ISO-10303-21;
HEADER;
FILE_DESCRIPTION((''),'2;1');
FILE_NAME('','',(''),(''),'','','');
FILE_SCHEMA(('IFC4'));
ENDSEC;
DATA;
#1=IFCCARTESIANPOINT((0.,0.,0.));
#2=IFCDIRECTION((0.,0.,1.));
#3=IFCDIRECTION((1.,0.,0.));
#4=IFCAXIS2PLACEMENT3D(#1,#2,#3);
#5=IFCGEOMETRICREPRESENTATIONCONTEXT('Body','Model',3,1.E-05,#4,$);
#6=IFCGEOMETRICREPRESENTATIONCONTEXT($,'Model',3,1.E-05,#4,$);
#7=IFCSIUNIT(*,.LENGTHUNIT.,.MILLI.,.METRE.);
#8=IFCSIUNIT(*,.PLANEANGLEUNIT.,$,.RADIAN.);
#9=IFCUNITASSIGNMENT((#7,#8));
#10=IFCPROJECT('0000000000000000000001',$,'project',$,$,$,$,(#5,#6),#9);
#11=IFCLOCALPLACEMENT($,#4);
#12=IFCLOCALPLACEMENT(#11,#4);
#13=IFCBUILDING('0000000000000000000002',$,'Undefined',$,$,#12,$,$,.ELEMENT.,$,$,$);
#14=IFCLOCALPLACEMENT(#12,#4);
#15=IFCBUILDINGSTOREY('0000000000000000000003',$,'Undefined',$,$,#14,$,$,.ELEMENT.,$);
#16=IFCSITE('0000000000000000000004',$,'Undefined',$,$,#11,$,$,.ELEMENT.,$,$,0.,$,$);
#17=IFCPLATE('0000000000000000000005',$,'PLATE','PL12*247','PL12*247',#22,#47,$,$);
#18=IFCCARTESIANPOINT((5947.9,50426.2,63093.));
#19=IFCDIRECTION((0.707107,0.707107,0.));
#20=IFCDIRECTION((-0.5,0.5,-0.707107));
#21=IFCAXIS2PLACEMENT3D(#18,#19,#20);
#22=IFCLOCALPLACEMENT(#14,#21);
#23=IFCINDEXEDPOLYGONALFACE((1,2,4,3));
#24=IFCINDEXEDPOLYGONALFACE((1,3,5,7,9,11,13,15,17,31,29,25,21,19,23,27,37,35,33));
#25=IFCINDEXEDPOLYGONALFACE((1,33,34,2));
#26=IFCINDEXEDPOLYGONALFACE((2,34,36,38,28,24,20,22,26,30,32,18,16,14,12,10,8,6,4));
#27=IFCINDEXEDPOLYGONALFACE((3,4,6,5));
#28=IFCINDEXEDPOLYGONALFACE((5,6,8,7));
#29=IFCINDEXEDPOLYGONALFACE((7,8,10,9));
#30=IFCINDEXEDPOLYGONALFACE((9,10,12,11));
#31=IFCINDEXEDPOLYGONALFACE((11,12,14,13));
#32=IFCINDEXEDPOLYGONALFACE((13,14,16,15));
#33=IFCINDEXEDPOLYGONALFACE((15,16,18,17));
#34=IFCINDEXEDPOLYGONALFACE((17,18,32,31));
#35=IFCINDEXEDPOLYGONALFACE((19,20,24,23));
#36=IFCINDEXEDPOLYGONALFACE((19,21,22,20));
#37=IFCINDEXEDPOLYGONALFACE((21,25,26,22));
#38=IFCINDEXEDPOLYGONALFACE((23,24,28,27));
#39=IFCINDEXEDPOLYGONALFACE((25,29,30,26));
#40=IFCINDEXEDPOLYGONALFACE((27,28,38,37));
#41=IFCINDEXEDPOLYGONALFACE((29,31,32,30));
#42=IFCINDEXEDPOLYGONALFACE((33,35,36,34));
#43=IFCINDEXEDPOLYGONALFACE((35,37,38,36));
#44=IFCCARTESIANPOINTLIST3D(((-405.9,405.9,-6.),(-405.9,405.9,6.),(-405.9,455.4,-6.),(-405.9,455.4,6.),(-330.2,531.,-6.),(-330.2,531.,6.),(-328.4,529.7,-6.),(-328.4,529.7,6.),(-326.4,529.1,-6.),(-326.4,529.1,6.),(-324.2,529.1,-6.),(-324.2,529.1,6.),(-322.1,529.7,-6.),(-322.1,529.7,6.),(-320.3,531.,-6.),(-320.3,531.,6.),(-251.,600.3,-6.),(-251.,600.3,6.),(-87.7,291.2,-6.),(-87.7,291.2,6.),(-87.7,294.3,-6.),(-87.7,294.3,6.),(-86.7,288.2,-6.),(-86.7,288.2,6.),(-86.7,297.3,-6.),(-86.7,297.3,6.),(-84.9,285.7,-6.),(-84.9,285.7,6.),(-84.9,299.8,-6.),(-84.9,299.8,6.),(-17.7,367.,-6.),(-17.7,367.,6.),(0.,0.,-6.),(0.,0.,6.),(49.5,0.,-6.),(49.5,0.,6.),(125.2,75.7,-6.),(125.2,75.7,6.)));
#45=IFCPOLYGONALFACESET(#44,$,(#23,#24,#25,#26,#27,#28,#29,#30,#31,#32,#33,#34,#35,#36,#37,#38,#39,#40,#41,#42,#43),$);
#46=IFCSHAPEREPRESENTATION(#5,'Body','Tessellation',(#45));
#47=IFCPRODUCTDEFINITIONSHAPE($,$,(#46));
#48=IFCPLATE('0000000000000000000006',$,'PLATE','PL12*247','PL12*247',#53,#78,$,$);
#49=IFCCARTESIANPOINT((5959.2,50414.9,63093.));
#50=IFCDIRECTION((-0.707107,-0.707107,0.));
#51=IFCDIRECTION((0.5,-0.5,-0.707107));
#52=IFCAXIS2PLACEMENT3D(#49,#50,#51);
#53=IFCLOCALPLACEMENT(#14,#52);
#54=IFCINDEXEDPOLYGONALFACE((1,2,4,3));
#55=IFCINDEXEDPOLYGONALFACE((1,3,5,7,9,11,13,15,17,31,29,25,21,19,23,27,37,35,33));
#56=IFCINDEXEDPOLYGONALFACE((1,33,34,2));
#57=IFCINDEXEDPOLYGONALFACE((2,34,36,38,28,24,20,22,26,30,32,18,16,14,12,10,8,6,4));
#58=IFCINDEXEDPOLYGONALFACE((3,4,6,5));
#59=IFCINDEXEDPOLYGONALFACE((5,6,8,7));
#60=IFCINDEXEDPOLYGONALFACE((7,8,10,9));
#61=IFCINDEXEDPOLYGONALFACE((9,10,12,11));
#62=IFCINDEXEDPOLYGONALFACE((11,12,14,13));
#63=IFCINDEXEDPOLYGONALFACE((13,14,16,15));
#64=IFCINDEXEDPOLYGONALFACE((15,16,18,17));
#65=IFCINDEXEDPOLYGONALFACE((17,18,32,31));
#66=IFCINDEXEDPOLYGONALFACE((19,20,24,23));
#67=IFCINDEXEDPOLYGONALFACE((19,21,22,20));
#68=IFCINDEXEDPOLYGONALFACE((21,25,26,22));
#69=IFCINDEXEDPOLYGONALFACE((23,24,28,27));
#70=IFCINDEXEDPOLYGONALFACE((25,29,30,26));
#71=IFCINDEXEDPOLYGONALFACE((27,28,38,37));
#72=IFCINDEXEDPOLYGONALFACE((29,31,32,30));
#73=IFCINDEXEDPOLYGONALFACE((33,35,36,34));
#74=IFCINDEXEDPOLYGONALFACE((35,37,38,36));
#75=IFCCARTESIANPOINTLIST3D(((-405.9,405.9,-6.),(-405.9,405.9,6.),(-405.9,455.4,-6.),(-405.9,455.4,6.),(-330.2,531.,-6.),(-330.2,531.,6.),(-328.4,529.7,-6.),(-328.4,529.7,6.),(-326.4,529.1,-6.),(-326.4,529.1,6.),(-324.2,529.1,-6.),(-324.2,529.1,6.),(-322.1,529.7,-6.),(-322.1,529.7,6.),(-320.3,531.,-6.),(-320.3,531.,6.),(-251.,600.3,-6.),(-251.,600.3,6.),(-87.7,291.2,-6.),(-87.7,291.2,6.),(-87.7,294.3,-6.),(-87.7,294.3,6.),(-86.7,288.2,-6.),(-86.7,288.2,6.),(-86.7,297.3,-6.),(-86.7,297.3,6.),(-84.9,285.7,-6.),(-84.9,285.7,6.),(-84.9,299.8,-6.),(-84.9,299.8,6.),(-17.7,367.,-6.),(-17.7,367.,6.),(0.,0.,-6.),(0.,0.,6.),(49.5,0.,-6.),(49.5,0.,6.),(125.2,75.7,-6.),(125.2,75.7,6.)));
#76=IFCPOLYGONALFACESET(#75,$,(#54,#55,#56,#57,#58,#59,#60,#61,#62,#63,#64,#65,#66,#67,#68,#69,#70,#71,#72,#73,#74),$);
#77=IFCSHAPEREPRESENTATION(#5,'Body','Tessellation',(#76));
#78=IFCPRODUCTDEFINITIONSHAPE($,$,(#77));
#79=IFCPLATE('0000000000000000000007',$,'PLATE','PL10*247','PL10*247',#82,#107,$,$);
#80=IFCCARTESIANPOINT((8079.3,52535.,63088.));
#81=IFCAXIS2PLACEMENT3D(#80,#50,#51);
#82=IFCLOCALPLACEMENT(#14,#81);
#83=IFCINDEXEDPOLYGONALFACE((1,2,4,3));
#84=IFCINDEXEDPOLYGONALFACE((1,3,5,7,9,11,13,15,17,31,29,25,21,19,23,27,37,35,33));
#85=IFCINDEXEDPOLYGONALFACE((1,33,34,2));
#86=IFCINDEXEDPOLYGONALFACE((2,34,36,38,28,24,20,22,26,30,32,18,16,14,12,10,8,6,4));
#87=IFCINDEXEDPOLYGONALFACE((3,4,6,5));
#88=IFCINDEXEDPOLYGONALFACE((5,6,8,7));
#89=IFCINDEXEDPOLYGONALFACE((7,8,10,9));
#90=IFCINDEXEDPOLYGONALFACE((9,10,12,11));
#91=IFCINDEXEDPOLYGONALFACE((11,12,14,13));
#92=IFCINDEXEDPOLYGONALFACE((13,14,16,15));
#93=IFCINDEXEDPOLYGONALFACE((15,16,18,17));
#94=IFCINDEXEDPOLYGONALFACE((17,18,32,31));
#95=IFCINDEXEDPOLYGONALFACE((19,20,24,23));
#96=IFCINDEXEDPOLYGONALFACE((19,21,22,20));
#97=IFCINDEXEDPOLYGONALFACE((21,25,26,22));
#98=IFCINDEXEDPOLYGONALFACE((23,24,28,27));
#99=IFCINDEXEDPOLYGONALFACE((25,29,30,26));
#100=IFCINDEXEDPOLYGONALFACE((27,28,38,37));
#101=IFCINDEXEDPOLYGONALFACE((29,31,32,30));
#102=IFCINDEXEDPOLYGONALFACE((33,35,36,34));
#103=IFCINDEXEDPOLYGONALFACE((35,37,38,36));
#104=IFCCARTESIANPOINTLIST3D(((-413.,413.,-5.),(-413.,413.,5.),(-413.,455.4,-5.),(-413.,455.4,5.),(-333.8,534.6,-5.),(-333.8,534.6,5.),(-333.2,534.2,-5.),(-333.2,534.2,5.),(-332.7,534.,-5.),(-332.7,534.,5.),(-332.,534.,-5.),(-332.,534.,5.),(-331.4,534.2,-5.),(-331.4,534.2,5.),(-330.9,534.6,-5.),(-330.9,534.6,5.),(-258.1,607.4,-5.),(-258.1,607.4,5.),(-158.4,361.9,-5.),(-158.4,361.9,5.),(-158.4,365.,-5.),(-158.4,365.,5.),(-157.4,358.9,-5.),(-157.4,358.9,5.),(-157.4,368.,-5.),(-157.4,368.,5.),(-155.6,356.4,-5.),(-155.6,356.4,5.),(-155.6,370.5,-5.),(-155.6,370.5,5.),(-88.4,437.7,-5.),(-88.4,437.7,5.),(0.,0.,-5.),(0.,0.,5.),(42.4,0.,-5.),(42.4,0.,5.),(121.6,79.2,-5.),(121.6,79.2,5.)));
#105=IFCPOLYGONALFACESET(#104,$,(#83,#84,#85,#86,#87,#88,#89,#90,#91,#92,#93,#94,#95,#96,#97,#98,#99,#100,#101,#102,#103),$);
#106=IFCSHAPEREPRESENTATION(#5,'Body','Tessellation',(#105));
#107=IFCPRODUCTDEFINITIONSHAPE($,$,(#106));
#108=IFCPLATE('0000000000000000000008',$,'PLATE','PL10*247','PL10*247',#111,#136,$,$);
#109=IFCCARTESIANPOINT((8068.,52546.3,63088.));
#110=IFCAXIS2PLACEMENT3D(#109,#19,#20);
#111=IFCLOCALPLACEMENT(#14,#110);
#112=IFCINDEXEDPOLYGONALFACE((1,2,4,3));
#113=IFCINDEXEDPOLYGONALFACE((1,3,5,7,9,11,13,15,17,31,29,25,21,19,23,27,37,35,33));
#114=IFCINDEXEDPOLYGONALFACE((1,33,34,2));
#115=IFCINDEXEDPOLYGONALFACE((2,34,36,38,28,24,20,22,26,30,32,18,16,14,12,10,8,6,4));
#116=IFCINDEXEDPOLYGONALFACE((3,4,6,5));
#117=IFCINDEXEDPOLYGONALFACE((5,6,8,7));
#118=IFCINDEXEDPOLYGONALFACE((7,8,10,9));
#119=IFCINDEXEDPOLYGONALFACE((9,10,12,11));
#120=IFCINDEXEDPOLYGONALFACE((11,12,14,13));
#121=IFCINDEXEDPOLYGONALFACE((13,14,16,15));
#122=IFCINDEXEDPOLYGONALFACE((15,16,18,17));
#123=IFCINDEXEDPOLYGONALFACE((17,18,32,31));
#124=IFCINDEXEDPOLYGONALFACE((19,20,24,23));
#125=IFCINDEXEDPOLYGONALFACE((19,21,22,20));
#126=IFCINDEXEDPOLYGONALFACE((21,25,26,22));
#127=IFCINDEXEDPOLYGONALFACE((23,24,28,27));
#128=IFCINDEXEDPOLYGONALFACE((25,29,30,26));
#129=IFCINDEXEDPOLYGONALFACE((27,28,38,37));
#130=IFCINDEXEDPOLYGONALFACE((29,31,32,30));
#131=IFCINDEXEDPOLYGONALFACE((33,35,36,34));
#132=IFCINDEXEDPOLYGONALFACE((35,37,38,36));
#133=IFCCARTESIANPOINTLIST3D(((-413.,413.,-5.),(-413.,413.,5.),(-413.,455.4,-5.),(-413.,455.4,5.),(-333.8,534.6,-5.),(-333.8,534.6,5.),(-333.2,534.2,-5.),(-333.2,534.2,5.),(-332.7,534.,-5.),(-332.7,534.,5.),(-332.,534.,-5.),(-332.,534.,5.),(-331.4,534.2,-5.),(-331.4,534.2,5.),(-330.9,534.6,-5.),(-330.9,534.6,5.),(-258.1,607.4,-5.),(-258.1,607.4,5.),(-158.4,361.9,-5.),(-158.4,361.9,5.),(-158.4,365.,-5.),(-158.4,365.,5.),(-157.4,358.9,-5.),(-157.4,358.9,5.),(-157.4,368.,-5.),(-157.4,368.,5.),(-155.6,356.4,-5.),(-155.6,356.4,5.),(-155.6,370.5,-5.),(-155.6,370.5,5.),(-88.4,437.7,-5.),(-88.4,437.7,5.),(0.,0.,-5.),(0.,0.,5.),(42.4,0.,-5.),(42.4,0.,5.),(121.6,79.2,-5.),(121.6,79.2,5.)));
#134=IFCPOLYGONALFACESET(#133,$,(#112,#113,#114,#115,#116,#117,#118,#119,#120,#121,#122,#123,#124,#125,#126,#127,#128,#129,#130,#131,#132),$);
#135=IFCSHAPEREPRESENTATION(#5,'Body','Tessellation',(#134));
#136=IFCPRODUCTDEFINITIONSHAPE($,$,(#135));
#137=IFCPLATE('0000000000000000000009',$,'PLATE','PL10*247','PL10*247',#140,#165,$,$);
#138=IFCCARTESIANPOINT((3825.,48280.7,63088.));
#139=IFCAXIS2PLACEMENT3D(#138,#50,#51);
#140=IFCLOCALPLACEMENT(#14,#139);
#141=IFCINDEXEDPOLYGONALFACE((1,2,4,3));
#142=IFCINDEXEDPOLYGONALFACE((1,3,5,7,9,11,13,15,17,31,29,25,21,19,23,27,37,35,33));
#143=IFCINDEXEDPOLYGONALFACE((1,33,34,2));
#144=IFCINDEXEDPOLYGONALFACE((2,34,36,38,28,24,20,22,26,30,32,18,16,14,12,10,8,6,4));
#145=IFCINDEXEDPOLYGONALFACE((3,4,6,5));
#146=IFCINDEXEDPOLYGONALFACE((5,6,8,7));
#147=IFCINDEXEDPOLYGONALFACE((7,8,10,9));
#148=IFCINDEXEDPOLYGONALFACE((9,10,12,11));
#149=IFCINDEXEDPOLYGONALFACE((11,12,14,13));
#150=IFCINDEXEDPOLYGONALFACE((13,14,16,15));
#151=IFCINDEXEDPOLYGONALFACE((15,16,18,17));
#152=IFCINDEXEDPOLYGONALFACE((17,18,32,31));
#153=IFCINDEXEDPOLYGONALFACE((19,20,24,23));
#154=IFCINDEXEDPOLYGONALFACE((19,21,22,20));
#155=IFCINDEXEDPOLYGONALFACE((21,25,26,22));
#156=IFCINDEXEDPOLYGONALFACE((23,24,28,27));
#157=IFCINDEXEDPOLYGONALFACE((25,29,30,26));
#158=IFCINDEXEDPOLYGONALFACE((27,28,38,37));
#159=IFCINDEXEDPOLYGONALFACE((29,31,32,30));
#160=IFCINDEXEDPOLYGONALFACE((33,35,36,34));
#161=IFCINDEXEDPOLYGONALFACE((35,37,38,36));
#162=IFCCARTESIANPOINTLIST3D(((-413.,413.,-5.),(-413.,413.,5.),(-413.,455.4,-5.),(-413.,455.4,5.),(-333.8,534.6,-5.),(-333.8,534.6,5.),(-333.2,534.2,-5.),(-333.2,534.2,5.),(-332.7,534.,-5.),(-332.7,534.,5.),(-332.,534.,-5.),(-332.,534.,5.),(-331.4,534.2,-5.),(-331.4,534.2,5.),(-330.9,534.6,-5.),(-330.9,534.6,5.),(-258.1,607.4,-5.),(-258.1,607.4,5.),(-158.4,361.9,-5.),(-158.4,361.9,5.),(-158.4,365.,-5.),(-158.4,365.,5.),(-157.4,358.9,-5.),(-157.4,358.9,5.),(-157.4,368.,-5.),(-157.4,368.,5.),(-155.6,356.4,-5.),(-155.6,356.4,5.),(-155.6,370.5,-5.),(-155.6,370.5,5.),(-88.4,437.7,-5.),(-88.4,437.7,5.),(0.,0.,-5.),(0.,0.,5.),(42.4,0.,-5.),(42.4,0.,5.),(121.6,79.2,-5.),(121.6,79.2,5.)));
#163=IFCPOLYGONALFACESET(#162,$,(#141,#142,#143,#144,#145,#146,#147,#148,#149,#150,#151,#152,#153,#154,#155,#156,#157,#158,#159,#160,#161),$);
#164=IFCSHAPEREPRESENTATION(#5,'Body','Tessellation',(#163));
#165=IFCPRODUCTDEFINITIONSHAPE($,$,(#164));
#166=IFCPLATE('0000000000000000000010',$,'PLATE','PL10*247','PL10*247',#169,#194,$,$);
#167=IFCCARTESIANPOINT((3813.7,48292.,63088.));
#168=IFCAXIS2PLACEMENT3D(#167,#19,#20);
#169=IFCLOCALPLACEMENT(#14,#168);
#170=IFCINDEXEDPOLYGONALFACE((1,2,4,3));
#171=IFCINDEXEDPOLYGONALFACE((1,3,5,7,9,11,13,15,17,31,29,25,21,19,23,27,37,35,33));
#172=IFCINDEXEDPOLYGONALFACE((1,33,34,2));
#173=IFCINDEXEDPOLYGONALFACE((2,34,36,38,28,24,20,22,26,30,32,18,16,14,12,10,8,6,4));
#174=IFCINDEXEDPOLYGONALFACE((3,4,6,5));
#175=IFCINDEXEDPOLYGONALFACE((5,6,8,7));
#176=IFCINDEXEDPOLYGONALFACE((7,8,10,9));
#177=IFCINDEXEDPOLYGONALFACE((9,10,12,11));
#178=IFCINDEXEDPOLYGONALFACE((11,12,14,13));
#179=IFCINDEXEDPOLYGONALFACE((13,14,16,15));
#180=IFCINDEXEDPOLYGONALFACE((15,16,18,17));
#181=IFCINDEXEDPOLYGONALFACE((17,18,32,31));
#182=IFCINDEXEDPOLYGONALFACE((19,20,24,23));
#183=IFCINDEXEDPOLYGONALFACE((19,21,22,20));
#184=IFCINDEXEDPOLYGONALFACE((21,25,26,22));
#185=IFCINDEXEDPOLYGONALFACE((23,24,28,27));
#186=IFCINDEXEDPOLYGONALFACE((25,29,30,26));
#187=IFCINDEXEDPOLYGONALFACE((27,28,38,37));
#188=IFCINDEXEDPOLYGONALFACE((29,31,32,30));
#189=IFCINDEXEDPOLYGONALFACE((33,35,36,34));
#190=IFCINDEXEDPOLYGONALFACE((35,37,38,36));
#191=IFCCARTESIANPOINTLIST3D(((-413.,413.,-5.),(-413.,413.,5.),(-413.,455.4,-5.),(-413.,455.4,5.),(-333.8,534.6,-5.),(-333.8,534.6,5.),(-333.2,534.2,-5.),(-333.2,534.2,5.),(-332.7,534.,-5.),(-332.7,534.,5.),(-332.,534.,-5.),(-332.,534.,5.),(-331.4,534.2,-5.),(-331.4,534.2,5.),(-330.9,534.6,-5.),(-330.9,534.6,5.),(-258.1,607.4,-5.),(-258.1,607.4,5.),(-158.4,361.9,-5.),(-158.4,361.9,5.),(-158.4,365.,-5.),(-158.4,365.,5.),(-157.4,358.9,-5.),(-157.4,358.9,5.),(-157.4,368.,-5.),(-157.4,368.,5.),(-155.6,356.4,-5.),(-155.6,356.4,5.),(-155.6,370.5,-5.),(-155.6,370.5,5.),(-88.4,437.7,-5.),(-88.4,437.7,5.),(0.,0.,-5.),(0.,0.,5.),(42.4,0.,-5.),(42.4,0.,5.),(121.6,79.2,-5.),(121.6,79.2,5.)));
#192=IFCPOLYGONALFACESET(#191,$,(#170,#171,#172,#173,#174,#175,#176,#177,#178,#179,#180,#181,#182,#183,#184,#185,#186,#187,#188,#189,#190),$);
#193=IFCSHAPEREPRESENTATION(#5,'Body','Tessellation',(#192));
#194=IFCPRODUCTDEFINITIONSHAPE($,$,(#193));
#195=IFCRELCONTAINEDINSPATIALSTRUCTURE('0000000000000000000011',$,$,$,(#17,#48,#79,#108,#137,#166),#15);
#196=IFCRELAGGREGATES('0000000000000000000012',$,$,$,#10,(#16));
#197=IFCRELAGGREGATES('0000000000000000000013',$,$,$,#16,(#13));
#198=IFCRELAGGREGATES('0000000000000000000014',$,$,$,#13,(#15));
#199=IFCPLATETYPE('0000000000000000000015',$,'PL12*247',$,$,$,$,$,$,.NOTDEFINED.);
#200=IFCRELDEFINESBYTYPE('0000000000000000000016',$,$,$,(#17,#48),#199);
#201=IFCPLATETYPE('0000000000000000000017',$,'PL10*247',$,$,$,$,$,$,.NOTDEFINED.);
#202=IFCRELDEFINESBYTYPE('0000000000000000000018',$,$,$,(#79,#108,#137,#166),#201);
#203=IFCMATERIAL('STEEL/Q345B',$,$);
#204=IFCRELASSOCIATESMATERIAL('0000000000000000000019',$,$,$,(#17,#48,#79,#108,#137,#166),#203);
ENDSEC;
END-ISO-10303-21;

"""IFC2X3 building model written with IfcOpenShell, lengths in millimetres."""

from ifc_helpers import new_model, si_unit, frame, origin_with_axes, place, context, project, spatial, polyline, outline, extrude, material, type_object, element, save


model = new_model("IFC2X3")

# Units and contexts
model_context_1 = context("Model", 3, precision=1e-05, world=origin_with_axes(), identifier="Body")
model_context_2 = context("Model", 3, precision=1e-05, world=origin_with_axes())
ifc_project = project(units=[si_unit("LENGTHUNIT", "METRE", prefix="MILLI"), si_unit("PLANEANGLEUNIT", "RADIAN")], contexts=[model_context_1, model_context_2])

# Site, building, storey
site_placement = place(None, origin_with_axes())
site = spatial("IfcSite", under=ifc_project, at=site_placement, Name="Undefined", CompositionType="ELEMENT", RefElevation=0.0)
building_placement = place(site_placement, origin_with_axes())
building = spatial("IfcBuilding", under=site, at=building_placement, Name="Undefined", CompositionType="ELEMENT")
storey_placement = place(building_placement, origin_with_axes())
storey = spatial("IfcBuildingStorey", under=building, at=storey_placement, Name="Undefined", CompositionType="ELEMENT")

# Shared definitions
ifc_material_1 = material(Name="STEEL/Q345B")

# Plates
plate_type_1 = type_object("IfcPlateType", Name="PL12*247", PredefinedType="NOTDEFINED")
plate_1_placement = place(storey_placement, frame((5947.9, 50426.2, 63093.0), z_axis=(0.707107, 0.707107, 0.0), x_axis=(-0.5, 0.5, -0.707107)))
element("IfcPlate", 1, at=plate_1_placement, inside=storey, type_object=plate_type_1, material=ifc_material_1, Name="PLATE", Description="PL12*247", ObjectType="PL12*247", context=model_context_1, shape_type="SweptSolid", body=[
    extrude(outline(polyline([(0.0, 0.0), (49.5, 0.0), (125.2, 75.7), (-84.9, 285.7), (-86.7, 288.2), (-87.7, 291.2), (-87.7, 294.3), (-86.7, 297.3), (-84.9, 299.8), (-17.7, 367.0), (-251.0, 600.3), (-320.3, 531.0), (-322.1, 529.7), (-324.2, 529.1), (-326.4, 529.1), (-328.4, 529.7), (-330.2, 531.0), (-405.9, 455.4), (-405.9, 405.9), (0.0, 0.0)])), frame((0.0, 0.0, -6.0), z_axis=(0.0, 0.0, 1.0), x_axis=(1.0, 0.0, 0.0)), (0.0, 0.0, 1.0), 12.0),
])
plate_2_placement = place(storey_placement, frame((5959.2, 50414.9, 63093.0), z_axis=(-0.707107, -0.707107, 0.0), x_axis=(0.5, -0.5, -0.707107)))
element("IfcPlate", 2, at=plate_2_placement, inside=storey, type_object=plate_type_1, material=ifc_material_1, Name="PLATE", Description="PL12*247", ObjectType="PL12*247", context=model_context_1, shape_type="SweptSolid", body=[
    extrude(outline(polyline([(0.0, 0.0), (49.5, 0.0), (125.2, 75.7), (-84.9, 285.7), (-86.7, 288.2), (-87.7, 291.2), (-87.7, 294.3), (-86.7, 297.3), (-84.9, 299.8), (-17.7, 367.0), (-251.0, 600.3), (-320.3, 531.0), (-322.1, 529.7), (-324.2, 529.1), (-326.4, 529.1), (-328.4, 529.7), (-330.2, 531.0), (-405.9, 455.4), (-405.9, 405.9), (0.0, 0.0)])), frame((0.0, 0.0, -6.0), z_axis=(0.0, 0.0, 1.0), x_axis=(1.0, 0.0, 0.0)), (0.0, 0.0, 1.0), 12.0),
])
plate_type_2 = type_object("IfcPlateType", Name="PL10*247", PredefinedType="NOTDEFINED")
for number, where, z_axis, x_axis, name in (
    (3, (8079.3, 52535.0, 63088.0), (-0.707107, -0.707107, 0.0), (0.5, -0.5, -0.707107), "PLATE"),
    (4, (8068.0, 52546.3, 63088.0), (0.707107, 0.707107, 0.0), (-0.5, 0.5, -0.707107), "PLATE"),
):
    element("IfcPlate", number, at=place(storey_placement, frame(where, z_axis=z_axis, x_axis=x_axis)), inside=storey, type_object=plate_type_2, material=ifc_material_1, Name=name, Description="PL10*247", ObjectType="PL10*247", context=model_context_1, shape_type="SweptSolid", body=[
        extrude(outline(polyline([(0.0, 0.0), (42.4, 0.0), (121.6, 79.2), (-155.6, 356.4), (-157.4, 358.9), (-158.4, 361.9), (-158.4, 365.0), (-157.4, 368.0), (-155.6, 370.5), (-88.4, 437.7), (-258.1, 607.4), (-330.9, 534.6), (-331.4, 534.2), (-332.0, 534.0), (-332.7, 534.0), (-333.2, 534.2), (-333.8, 534.6), (-413.0, 455.4), (-413.0, 413.0), (0.0, 0.0)])), frame((0.0, 0.0, -5.0), z_axis=(0.0, 0.0, 1.0), x_axis=(1.0, 0.0, 0.0)), (0.0, 0.0, 1.0), 10.0),
    ])
plate_3_placement = place(storey_placement, frame((3825.0, 48280.7, 63088.0), z_axis=(-0.707107, -0.707107, 0.0), x_axis=(0.5, -0.5, -0.707107)))
element("IfcPlate", 5, at=plate_3_placement, inside=storey, type_object=plate_type_2, material=ifc_material_1, Name="PLATE", Description="PL10*247", ObjectType="PL10*247", context=model_context_1, shape_type="SweptSolid", body=[
    extrude(outline(polyline([(0.0, 0.0), (42.4, 0.0), (121.6, 79.2), (-155.6, 356.4), (-157.4, 358.9), (-158.4, 361.9), (-158.4, 365.0), (-157.4, 368.0), (-155.6, 370.5), (-88.4, 437.7), (-258.1, 607.4), (-330.9, 534.6), (-331.4, 534.2), (-332.0, 534.0), (-332.7, 534.0), (-333.2, 534.2), (-333.8, 534.6), (-413.0, 455.4), (-413.0, 413.0), (0.0, 0.0)])), frame((0.0, 0.0, -5.0), z_axis=(0.0, 0.0, 1.0), x_axis=(1.0, 0.0, 0.0)), (0.0, 0.0, 1.0), 10.0),
])
plate_4_placement = place(storey_placement, frame((3813.7, 48292.0, 63088.0), z_axis=(0.707107, 0.707107, 0.0), x_axis=(-0.5, 0.5, -0.707107)))
element("IfcPlate", 6, at=plate_4_placement, inside=storey, type_object=plate_type_2, material=ifc_material_1, Name="PLATE", Description="PL10*247", ObjectType="PL10*247", context=model_context_1, shape_type="SweptSolid", body=[
    extrude(outline(polyline([(0.0, 0.0), (42.4, 0.0), (121.6, 79.2), (-155.6, 356.4), (-157.4, 358.9), (-158.4, 361.9), (-158.4, 365.0), (-157.4, 368.0), (-155.6, 370.5), (-88.4, 437.7), (-258.1, 607.4), (-330.9, 534.6), (-331.4, 534.2), (-332.0, 534.0), (-332.7, 534.0), (-333.2, 534.2), (-333.8, 534.6), (-413.0, 455.4), (-413.0, 413.0), (0.0, 0.0)])), frame((0.0, 0.0, -5.0), z_axis=(0.0, 0.0, 1.0), x_axis=(1.0, 0.0, 0.0)), (0.0, 0.0, 1.0), 10.0),
])

save(model, "model.ifc")
